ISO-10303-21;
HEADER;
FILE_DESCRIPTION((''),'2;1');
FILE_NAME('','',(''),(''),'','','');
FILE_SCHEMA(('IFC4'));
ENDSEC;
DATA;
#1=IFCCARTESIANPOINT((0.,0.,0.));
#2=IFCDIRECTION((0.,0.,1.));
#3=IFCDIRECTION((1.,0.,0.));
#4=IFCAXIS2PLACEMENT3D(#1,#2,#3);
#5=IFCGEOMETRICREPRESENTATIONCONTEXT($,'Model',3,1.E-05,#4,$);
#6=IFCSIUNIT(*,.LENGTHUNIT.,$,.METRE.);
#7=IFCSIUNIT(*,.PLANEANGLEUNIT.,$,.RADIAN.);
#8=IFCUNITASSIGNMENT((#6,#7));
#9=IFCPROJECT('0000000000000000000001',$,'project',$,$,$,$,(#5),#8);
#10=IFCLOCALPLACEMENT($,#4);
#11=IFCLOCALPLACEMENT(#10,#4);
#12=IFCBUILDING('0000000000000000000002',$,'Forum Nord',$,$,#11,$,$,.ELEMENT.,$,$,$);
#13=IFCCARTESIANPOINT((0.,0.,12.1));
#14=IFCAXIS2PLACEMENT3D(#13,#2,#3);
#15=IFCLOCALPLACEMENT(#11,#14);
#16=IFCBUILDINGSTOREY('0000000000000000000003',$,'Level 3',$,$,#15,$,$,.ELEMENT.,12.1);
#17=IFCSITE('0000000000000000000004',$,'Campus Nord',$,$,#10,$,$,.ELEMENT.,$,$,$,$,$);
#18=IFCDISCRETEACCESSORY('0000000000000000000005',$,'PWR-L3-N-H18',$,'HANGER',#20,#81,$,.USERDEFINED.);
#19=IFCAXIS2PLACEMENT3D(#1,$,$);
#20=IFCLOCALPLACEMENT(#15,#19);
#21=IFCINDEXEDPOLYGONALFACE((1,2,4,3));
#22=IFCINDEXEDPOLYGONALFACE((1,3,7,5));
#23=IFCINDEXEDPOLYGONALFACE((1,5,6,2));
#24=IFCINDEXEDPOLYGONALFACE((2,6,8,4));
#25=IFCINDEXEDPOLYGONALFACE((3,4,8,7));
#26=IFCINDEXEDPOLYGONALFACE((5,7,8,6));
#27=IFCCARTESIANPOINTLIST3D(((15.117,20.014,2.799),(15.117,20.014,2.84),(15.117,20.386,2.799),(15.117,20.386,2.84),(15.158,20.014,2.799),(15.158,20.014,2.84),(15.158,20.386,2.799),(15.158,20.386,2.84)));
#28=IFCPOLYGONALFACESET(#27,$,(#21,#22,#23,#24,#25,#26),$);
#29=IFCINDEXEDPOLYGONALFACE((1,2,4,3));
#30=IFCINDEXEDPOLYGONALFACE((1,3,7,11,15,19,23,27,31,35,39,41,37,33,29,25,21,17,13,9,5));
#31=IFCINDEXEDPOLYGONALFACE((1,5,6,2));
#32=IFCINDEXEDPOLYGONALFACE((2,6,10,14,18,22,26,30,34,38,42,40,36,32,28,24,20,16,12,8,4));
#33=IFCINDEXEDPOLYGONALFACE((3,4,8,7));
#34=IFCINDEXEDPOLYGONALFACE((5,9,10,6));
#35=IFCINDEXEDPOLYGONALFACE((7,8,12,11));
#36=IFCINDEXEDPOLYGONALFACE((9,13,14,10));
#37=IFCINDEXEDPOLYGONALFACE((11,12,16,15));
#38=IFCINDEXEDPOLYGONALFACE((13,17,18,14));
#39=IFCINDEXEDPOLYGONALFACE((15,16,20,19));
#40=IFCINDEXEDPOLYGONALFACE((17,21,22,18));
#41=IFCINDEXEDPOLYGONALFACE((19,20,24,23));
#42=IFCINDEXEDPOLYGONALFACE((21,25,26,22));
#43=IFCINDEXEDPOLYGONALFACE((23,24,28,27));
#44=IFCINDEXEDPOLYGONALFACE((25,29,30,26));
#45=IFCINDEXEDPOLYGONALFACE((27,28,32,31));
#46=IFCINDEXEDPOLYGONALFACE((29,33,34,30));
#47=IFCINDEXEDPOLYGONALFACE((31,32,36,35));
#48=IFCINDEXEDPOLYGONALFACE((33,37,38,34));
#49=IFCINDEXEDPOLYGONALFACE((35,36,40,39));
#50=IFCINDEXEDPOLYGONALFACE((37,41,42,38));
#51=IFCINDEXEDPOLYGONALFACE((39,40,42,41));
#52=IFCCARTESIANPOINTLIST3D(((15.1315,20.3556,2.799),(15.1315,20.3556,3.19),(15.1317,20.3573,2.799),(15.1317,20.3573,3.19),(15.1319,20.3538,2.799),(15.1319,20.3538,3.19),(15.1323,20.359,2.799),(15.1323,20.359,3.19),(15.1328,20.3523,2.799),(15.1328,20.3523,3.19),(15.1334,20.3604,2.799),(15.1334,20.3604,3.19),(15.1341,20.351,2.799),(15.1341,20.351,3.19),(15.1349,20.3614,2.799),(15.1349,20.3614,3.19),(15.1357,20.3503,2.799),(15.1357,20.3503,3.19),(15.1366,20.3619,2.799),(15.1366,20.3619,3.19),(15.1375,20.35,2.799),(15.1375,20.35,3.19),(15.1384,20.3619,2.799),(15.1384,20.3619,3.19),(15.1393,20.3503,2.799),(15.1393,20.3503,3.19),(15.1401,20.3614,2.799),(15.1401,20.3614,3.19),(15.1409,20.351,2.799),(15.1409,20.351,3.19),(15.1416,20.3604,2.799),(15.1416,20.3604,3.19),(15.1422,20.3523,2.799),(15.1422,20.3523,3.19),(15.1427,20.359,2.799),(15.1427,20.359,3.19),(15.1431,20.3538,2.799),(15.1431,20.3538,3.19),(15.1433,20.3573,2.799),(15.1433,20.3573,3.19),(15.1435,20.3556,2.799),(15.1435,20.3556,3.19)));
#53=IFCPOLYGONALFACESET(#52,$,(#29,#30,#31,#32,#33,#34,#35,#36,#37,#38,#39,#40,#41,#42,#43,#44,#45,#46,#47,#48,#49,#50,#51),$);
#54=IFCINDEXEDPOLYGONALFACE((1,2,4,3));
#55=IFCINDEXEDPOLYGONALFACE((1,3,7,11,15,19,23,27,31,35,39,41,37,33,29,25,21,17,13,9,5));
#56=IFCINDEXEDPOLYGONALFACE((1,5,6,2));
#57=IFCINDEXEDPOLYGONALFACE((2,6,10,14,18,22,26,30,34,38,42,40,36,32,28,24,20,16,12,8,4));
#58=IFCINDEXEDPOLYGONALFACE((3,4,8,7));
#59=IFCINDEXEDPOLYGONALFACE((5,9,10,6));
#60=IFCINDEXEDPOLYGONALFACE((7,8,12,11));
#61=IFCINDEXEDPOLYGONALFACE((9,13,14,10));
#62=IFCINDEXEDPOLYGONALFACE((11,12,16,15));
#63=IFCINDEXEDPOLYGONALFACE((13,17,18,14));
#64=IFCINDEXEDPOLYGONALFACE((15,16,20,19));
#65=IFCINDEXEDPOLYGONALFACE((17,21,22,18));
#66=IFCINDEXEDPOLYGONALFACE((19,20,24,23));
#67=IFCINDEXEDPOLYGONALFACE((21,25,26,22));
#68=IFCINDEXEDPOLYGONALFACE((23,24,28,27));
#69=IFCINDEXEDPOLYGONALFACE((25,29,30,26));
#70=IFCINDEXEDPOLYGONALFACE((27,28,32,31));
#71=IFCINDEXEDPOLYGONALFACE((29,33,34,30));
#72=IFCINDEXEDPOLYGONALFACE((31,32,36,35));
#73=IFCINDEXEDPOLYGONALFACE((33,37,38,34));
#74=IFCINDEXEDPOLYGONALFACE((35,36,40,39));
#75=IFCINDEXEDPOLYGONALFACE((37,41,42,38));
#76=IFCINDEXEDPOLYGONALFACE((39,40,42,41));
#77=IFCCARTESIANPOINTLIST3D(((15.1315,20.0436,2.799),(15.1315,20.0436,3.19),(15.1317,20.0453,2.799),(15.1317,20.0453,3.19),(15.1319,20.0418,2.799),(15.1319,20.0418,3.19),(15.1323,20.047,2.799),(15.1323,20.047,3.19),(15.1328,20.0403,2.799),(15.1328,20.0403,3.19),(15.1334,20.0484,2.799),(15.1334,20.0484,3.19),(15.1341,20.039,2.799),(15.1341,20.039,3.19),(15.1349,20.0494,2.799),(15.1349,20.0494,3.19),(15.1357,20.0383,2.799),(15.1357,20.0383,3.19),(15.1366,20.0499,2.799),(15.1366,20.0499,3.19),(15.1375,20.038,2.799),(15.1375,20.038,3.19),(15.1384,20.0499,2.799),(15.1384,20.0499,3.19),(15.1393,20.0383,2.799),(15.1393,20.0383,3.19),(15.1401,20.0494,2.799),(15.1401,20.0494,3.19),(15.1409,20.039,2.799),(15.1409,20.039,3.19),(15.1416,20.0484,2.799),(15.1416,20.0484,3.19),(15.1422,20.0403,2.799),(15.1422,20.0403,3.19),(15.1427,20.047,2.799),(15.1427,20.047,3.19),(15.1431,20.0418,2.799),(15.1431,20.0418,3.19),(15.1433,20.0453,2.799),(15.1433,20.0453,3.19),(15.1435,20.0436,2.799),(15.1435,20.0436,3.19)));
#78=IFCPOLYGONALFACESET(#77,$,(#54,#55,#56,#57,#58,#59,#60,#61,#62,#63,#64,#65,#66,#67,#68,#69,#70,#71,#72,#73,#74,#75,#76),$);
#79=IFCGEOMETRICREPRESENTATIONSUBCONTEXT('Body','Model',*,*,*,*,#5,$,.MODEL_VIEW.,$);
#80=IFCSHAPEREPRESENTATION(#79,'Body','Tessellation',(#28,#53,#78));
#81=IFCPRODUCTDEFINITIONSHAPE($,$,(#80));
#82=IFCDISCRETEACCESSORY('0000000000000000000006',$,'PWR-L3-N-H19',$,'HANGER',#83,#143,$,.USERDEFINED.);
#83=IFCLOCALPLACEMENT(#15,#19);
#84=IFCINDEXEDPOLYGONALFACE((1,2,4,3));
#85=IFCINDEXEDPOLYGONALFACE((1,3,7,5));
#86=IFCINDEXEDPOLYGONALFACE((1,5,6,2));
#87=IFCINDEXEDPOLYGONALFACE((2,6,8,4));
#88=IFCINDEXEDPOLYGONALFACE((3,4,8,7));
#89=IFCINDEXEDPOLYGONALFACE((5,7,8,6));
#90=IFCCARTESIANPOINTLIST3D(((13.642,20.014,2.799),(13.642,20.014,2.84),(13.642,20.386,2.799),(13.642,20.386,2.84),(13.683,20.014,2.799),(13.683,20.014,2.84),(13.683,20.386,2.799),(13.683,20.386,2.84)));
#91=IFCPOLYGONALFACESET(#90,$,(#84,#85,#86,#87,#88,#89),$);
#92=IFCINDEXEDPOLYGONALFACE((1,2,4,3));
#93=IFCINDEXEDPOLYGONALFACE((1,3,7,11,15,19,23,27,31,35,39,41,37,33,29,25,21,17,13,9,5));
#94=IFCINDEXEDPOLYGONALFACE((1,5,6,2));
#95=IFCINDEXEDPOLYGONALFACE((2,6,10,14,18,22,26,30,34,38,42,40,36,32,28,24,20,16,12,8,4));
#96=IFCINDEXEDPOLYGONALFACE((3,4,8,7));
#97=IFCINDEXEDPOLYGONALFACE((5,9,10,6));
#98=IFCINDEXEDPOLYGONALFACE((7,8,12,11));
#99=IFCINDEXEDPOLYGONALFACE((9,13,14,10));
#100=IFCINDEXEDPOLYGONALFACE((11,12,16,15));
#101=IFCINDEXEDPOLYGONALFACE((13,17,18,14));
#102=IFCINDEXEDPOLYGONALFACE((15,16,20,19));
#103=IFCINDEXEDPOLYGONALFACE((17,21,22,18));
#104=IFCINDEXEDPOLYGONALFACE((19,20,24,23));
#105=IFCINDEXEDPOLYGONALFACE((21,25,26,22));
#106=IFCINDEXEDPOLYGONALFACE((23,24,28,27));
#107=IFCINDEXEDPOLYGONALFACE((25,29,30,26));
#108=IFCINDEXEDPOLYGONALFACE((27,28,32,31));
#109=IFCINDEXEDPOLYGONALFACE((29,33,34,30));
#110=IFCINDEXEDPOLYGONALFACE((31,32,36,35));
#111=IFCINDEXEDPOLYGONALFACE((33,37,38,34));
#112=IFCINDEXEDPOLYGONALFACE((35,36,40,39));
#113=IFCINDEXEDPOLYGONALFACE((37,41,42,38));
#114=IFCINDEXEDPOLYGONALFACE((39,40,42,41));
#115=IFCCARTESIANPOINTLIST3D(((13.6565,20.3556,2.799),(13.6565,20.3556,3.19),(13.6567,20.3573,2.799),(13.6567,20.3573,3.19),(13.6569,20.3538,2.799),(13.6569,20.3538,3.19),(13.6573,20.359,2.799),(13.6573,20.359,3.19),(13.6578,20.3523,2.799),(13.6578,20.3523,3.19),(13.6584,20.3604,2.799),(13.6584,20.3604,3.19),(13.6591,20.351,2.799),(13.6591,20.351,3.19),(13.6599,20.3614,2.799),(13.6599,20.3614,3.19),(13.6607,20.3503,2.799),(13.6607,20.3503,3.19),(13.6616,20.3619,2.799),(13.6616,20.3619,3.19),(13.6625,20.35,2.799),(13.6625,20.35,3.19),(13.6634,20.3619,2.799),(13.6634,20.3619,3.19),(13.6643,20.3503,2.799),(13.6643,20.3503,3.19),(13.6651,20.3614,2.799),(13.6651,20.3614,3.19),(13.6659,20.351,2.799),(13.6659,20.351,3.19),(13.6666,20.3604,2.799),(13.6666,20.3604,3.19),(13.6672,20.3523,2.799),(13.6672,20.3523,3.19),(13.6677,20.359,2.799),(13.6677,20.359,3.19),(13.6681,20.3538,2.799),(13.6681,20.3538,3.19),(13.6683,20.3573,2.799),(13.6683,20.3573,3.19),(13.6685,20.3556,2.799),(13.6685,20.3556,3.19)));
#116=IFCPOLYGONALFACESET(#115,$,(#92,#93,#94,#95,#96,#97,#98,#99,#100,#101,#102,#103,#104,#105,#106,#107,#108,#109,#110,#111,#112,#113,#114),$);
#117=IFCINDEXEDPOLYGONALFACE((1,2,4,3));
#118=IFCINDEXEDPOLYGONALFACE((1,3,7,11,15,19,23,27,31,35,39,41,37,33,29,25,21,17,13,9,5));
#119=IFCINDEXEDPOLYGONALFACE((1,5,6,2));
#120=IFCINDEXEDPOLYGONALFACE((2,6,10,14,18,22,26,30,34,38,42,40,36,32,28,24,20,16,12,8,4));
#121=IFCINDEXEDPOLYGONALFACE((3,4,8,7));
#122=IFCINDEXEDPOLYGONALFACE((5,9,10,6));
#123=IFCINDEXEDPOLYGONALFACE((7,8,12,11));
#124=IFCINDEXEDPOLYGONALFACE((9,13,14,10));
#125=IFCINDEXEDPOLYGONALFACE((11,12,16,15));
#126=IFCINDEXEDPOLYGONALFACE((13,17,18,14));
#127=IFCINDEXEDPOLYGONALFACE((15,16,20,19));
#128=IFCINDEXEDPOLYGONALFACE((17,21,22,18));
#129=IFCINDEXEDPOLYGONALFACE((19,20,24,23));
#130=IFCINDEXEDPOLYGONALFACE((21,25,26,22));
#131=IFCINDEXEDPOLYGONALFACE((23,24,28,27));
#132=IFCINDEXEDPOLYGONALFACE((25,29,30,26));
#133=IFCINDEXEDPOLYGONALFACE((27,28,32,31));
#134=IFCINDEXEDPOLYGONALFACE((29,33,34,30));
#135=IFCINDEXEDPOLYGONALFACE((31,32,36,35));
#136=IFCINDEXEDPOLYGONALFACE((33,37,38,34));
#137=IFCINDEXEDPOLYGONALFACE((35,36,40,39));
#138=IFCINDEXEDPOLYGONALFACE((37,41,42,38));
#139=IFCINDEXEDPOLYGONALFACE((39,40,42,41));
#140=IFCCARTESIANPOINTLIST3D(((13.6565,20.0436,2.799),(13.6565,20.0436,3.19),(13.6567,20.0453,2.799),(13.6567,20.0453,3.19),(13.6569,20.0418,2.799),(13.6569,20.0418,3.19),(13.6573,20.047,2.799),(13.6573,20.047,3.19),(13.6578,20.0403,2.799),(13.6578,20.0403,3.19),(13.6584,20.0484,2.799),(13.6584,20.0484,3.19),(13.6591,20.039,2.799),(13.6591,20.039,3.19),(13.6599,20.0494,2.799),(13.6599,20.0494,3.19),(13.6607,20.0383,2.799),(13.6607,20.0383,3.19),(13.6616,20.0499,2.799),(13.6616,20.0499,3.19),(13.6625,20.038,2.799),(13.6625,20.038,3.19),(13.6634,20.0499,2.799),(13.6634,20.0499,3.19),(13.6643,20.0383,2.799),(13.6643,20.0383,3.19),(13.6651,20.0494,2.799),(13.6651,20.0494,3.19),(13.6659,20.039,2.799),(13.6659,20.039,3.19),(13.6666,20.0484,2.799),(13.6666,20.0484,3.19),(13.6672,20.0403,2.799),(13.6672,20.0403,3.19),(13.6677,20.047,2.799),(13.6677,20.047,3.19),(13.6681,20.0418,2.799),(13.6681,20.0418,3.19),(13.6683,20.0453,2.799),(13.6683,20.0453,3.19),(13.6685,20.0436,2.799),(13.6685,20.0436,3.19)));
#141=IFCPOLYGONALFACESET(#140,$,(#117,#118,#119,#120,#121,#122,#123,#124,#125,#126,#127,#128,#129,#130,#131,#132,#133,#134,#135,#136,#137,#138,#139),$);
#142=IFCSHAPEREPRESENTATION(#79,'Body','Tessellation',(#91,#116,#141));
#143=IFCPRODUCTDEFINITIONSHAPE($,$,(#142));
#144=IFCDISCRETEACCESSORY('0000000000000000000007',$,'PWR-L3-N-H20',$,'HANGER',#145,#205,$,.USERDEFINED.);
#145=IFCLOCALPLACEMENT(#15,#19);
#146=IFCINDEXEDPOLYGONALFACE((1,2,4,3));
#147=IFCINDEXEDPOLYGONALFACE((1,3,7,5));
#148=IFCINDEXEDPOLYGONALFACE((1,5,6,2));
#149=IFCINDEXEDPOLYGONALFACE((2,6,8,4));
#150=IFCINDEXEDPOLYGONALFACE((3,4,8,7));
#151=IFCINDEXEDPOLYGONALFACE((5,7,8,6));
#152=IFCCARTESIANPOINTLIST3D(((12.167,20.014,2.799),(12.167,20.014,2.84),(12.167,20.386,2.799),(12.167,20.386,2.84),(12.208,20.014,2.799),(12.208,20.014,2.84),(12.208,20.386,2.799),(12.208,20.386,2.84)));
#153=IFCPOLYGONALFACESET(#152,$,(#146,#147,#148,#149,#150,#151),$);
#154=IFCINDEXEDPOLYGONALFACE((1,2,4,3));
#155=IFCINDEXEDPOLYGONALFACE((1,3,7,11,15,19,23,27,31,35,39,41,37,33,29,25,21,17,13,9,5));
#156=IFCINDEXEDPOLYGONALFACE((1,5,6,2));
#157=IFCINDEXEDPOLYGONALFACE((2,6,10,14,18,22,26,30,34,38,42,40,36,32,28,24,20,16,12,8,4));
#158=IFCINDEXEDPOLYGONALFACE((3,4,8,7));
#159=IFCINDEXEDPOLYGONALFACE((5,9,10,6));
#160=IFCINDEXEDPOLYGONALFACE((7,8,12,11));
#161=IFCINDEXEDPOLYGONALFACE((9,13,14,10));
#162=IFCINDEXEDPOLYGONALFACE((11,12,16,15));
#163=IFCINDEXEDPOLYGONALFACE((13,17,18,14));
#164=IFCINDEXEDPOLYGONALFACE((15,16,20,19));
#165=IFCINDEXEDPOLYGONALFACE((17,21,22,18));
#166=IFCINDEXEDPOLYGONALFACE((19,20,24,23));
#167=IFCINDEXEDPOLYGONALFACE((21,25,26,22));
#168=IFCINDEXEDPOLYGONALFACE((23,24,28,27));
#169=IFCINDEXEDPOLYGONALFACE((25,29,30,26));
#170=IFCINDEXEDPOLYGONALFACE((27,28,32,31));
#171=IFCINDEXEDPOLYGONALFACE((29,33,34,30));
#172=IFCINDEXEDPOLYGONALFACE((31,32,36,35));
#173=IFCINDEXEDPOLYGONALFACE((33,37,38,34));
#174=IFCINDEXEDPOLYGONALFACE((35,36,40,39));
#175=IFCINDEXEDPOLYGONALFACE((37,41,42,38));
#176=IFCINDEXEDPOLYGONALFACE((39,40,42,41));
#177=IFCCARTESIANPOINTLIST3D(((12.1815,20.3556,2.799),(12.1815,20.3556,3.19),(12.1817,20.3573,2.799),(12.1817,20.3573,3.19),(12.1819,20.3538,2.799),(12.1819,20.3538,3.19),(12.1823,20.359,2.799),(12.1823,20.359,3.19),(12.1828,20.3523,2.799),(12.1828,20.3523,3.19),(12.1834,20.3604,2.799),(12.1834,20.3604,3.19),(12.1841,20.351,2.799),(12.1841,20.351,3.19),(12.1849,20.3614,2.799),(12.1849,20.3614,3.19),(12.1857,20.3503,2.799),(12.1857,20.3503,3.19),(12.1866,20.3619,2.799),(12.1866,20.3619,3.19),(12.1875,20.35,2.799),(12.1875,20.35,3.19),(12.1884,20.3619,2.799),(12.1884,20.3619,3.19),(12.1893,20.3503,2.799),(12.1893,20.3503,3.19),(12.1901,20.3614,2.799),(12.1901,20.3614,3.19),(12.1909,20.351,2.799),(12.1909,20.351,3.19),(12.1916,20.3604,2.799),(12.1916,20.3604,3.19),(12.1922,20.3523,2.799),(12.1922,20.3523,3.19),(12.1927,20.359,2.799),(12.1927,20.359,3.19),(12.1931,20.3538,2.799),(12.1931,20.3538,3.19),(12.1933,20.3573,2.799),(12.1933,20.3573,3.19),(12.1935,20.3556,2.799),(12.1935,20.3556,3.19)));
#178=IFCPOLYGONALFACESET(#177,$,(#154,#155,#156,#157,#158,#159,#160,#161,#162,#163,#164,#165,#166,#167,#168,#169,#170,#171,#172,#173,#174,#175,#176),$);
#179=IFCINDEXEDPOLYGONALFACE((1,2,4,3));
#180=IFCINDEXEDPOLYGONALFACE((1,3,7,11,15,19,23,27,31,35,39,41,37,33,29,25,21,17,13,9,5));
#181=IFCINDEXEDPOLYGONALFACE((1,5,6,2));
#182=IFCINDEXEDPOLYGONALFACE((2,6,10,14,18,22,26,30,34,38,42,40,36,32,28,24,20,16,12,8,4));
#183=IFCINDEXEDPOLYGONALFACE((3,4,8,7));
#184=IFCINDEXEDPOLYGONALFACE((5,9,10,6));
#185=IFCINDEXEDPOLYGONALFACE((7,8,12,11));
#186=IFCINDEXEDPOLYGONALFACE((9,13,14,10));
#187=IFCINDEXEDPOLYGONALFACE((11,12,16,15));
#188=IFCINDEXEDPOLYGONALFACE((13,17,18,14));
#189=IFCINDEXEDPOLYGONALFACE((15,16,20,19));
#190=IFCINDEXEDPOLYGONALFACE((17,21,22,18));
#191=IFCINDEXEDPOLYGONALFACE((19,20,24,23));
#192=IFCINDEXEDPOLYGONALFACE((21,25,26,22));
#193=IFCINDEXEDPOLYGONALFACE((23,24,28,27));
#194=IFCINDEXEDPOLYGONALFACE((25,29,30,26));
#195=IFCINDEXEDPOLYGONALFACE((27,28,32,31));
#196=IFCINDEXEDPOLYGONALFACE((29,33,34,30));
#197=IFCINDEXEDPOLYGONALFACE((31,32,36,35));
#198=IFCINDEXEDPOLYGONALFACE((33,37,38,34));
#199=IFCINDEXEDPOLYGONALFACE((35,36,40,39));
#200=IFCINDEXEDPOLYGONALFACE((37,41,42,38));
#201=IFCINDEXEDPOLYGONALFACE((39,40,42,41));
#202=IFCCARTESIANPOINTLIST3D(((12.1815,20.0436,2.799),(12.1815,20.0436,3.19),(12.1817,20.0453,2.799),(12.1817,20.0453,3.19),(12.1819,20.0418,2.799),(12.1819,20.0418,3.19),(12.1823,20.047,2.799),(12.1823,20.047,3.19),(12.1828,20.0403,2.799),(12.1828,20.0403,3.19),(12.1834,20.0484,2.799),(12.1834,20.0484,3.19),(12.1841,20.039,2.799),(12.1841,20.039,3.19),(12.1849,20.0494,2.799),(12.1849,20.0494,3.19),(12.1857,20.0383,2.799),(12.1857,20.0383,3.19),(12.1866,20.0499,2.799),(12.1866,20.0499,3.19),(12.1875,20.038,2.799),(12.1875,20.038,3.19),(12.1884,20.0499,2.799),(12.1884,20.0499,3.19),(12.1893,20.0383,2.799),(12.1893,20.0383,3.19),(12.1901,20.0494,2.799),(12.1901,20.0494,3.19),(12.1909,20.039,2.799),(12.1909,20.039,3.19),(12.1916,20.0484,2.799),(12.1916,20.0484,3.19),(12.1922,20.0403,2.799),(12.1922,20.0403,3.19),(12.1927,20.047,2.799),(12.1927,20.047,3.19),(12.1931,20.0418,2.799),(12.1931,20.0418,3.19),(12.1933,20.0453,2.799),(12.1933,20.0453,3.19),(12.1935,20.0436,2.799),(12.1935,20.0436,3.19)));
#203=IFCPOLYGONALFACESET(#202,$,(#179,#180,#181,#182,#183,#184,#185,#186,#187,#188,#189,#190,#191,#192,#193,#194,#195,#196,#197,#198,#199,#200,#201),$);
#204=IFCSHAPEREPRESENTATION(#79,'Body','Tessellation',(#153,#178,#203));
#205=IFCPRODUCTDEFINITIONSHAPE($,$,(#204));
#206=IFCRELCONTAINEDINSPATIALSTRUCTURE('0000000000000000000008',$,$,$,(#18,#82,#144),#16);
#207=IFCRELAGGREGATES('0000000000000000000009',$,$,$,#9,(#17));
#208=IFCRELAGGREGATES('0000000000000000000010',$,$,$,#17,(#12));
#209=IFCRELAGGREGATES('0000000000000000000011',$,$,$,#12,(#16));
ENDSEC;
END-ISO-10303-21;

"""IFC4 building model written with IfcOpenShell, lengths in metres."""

from ifc_helpers import new_model, si_unit, frame, frame_2d, origin_with_axes, origin_2d_with_axis, place, context, subcontext, project, spatial, rectangle, circle, extrude, element, save


model = new_model("IFC4")

# Units and contexts
model_context = context("Model", 3, precision=1e-05, world=origin_with_axes())
body_context = subcontext(model_context, "Body", "Model", "MODEL_VIEW")
ifc_project = project(units=[si_unit("LENGTHUNIT", "METRE"), si_unit("PLANEANGLEUNIT", "RADIAN")], contexts=[model_context])

# Site, building, storey
site_placement = place(None, origin_with_axes())
site = spatial("IfcSite", under=ifc_project, at=site_placement, Name="Campus Nord", CompositionType="ELEMENT")
building_placement = place(site_placement, origin_with_axes())
building = spatial("IfcBuilding", under=site, at=building_placement, Name="Forum Nord", CompositionType="ELEMENT")
storey_placement = place(building_placement, frame((0.0, 0.0, 12.1), z_axis=(0.0, 0.0, 1.0), x_axis=(1.0, 0.0, 0.0)))
storey = spatial("IfcBuildingStorey", under=building, at=storey_placement, Name="Level 3", CompositionType="ELEMENT", Elevation=12.1)

# Discrete accessories
for number, where, z_axis, x_axis, name in (
    (1, (15.1375, 20.2, 2.84), (0.0, 0.0, 1.0), (0.0, -1.0, 0.0), "PWR-L3-N-H18"),
    (2, (13.6625, 20.2, 2.84), (0.0, 0.0, 1.0), (0.0, -1.0, 0.0), "PWR-L3-N-H19"),
    (3, (12.1875, 20.2, 2.84), (0.0, 0.0, 1.0), (0.0, -1.0, 0.0), "PWR-L3-N-H20"),
):
    element("IfcDiscreteAccessory", number, at=place(storey_placement, frame(where, z_axis=z_axis, x_axis=x_axis)), inside=storey, Name=name, ObjectType="HANGER", PredefinedType="USERDEFINED", context=body_context, shape_type="SweptSolid", body=[
        extrude(rectangle(XDim=0.372, YDim=0.041, at=origin_2d_with_axis()), frame((0.0, 0.0, -0.041), z_axis=(0.0, 0.0, 1.0), x_axis=(1.0, 0.0, 0.0)), (0.0, 0.0, 1.0), 0.041),
        extrude(circle(Radius=0.006, at=frame_2d((-0.156, 0.0), x_axis=(1.0, 0.0))), frame((0.0, 0.0, -0.041), z_axis=(0.0, 0.0, 1.0), x_axis=(1.0, 0.0, 0.0)), (0.0, 0.0, 1.0), 0.391),
        extrude(circle(Radius=0.006, at=frame_2d((0.156, 0.0), x_axis=(1.0, 0.0))), frame((0.0, 0.0, -0.041), z_axis=(0.0, 0.0, 1.0), x_axis=(1.0, 0.0, 0.0)), (0.0, 0.0, 1.0), 0.391),
    ])

save(model, "model.ifc")
